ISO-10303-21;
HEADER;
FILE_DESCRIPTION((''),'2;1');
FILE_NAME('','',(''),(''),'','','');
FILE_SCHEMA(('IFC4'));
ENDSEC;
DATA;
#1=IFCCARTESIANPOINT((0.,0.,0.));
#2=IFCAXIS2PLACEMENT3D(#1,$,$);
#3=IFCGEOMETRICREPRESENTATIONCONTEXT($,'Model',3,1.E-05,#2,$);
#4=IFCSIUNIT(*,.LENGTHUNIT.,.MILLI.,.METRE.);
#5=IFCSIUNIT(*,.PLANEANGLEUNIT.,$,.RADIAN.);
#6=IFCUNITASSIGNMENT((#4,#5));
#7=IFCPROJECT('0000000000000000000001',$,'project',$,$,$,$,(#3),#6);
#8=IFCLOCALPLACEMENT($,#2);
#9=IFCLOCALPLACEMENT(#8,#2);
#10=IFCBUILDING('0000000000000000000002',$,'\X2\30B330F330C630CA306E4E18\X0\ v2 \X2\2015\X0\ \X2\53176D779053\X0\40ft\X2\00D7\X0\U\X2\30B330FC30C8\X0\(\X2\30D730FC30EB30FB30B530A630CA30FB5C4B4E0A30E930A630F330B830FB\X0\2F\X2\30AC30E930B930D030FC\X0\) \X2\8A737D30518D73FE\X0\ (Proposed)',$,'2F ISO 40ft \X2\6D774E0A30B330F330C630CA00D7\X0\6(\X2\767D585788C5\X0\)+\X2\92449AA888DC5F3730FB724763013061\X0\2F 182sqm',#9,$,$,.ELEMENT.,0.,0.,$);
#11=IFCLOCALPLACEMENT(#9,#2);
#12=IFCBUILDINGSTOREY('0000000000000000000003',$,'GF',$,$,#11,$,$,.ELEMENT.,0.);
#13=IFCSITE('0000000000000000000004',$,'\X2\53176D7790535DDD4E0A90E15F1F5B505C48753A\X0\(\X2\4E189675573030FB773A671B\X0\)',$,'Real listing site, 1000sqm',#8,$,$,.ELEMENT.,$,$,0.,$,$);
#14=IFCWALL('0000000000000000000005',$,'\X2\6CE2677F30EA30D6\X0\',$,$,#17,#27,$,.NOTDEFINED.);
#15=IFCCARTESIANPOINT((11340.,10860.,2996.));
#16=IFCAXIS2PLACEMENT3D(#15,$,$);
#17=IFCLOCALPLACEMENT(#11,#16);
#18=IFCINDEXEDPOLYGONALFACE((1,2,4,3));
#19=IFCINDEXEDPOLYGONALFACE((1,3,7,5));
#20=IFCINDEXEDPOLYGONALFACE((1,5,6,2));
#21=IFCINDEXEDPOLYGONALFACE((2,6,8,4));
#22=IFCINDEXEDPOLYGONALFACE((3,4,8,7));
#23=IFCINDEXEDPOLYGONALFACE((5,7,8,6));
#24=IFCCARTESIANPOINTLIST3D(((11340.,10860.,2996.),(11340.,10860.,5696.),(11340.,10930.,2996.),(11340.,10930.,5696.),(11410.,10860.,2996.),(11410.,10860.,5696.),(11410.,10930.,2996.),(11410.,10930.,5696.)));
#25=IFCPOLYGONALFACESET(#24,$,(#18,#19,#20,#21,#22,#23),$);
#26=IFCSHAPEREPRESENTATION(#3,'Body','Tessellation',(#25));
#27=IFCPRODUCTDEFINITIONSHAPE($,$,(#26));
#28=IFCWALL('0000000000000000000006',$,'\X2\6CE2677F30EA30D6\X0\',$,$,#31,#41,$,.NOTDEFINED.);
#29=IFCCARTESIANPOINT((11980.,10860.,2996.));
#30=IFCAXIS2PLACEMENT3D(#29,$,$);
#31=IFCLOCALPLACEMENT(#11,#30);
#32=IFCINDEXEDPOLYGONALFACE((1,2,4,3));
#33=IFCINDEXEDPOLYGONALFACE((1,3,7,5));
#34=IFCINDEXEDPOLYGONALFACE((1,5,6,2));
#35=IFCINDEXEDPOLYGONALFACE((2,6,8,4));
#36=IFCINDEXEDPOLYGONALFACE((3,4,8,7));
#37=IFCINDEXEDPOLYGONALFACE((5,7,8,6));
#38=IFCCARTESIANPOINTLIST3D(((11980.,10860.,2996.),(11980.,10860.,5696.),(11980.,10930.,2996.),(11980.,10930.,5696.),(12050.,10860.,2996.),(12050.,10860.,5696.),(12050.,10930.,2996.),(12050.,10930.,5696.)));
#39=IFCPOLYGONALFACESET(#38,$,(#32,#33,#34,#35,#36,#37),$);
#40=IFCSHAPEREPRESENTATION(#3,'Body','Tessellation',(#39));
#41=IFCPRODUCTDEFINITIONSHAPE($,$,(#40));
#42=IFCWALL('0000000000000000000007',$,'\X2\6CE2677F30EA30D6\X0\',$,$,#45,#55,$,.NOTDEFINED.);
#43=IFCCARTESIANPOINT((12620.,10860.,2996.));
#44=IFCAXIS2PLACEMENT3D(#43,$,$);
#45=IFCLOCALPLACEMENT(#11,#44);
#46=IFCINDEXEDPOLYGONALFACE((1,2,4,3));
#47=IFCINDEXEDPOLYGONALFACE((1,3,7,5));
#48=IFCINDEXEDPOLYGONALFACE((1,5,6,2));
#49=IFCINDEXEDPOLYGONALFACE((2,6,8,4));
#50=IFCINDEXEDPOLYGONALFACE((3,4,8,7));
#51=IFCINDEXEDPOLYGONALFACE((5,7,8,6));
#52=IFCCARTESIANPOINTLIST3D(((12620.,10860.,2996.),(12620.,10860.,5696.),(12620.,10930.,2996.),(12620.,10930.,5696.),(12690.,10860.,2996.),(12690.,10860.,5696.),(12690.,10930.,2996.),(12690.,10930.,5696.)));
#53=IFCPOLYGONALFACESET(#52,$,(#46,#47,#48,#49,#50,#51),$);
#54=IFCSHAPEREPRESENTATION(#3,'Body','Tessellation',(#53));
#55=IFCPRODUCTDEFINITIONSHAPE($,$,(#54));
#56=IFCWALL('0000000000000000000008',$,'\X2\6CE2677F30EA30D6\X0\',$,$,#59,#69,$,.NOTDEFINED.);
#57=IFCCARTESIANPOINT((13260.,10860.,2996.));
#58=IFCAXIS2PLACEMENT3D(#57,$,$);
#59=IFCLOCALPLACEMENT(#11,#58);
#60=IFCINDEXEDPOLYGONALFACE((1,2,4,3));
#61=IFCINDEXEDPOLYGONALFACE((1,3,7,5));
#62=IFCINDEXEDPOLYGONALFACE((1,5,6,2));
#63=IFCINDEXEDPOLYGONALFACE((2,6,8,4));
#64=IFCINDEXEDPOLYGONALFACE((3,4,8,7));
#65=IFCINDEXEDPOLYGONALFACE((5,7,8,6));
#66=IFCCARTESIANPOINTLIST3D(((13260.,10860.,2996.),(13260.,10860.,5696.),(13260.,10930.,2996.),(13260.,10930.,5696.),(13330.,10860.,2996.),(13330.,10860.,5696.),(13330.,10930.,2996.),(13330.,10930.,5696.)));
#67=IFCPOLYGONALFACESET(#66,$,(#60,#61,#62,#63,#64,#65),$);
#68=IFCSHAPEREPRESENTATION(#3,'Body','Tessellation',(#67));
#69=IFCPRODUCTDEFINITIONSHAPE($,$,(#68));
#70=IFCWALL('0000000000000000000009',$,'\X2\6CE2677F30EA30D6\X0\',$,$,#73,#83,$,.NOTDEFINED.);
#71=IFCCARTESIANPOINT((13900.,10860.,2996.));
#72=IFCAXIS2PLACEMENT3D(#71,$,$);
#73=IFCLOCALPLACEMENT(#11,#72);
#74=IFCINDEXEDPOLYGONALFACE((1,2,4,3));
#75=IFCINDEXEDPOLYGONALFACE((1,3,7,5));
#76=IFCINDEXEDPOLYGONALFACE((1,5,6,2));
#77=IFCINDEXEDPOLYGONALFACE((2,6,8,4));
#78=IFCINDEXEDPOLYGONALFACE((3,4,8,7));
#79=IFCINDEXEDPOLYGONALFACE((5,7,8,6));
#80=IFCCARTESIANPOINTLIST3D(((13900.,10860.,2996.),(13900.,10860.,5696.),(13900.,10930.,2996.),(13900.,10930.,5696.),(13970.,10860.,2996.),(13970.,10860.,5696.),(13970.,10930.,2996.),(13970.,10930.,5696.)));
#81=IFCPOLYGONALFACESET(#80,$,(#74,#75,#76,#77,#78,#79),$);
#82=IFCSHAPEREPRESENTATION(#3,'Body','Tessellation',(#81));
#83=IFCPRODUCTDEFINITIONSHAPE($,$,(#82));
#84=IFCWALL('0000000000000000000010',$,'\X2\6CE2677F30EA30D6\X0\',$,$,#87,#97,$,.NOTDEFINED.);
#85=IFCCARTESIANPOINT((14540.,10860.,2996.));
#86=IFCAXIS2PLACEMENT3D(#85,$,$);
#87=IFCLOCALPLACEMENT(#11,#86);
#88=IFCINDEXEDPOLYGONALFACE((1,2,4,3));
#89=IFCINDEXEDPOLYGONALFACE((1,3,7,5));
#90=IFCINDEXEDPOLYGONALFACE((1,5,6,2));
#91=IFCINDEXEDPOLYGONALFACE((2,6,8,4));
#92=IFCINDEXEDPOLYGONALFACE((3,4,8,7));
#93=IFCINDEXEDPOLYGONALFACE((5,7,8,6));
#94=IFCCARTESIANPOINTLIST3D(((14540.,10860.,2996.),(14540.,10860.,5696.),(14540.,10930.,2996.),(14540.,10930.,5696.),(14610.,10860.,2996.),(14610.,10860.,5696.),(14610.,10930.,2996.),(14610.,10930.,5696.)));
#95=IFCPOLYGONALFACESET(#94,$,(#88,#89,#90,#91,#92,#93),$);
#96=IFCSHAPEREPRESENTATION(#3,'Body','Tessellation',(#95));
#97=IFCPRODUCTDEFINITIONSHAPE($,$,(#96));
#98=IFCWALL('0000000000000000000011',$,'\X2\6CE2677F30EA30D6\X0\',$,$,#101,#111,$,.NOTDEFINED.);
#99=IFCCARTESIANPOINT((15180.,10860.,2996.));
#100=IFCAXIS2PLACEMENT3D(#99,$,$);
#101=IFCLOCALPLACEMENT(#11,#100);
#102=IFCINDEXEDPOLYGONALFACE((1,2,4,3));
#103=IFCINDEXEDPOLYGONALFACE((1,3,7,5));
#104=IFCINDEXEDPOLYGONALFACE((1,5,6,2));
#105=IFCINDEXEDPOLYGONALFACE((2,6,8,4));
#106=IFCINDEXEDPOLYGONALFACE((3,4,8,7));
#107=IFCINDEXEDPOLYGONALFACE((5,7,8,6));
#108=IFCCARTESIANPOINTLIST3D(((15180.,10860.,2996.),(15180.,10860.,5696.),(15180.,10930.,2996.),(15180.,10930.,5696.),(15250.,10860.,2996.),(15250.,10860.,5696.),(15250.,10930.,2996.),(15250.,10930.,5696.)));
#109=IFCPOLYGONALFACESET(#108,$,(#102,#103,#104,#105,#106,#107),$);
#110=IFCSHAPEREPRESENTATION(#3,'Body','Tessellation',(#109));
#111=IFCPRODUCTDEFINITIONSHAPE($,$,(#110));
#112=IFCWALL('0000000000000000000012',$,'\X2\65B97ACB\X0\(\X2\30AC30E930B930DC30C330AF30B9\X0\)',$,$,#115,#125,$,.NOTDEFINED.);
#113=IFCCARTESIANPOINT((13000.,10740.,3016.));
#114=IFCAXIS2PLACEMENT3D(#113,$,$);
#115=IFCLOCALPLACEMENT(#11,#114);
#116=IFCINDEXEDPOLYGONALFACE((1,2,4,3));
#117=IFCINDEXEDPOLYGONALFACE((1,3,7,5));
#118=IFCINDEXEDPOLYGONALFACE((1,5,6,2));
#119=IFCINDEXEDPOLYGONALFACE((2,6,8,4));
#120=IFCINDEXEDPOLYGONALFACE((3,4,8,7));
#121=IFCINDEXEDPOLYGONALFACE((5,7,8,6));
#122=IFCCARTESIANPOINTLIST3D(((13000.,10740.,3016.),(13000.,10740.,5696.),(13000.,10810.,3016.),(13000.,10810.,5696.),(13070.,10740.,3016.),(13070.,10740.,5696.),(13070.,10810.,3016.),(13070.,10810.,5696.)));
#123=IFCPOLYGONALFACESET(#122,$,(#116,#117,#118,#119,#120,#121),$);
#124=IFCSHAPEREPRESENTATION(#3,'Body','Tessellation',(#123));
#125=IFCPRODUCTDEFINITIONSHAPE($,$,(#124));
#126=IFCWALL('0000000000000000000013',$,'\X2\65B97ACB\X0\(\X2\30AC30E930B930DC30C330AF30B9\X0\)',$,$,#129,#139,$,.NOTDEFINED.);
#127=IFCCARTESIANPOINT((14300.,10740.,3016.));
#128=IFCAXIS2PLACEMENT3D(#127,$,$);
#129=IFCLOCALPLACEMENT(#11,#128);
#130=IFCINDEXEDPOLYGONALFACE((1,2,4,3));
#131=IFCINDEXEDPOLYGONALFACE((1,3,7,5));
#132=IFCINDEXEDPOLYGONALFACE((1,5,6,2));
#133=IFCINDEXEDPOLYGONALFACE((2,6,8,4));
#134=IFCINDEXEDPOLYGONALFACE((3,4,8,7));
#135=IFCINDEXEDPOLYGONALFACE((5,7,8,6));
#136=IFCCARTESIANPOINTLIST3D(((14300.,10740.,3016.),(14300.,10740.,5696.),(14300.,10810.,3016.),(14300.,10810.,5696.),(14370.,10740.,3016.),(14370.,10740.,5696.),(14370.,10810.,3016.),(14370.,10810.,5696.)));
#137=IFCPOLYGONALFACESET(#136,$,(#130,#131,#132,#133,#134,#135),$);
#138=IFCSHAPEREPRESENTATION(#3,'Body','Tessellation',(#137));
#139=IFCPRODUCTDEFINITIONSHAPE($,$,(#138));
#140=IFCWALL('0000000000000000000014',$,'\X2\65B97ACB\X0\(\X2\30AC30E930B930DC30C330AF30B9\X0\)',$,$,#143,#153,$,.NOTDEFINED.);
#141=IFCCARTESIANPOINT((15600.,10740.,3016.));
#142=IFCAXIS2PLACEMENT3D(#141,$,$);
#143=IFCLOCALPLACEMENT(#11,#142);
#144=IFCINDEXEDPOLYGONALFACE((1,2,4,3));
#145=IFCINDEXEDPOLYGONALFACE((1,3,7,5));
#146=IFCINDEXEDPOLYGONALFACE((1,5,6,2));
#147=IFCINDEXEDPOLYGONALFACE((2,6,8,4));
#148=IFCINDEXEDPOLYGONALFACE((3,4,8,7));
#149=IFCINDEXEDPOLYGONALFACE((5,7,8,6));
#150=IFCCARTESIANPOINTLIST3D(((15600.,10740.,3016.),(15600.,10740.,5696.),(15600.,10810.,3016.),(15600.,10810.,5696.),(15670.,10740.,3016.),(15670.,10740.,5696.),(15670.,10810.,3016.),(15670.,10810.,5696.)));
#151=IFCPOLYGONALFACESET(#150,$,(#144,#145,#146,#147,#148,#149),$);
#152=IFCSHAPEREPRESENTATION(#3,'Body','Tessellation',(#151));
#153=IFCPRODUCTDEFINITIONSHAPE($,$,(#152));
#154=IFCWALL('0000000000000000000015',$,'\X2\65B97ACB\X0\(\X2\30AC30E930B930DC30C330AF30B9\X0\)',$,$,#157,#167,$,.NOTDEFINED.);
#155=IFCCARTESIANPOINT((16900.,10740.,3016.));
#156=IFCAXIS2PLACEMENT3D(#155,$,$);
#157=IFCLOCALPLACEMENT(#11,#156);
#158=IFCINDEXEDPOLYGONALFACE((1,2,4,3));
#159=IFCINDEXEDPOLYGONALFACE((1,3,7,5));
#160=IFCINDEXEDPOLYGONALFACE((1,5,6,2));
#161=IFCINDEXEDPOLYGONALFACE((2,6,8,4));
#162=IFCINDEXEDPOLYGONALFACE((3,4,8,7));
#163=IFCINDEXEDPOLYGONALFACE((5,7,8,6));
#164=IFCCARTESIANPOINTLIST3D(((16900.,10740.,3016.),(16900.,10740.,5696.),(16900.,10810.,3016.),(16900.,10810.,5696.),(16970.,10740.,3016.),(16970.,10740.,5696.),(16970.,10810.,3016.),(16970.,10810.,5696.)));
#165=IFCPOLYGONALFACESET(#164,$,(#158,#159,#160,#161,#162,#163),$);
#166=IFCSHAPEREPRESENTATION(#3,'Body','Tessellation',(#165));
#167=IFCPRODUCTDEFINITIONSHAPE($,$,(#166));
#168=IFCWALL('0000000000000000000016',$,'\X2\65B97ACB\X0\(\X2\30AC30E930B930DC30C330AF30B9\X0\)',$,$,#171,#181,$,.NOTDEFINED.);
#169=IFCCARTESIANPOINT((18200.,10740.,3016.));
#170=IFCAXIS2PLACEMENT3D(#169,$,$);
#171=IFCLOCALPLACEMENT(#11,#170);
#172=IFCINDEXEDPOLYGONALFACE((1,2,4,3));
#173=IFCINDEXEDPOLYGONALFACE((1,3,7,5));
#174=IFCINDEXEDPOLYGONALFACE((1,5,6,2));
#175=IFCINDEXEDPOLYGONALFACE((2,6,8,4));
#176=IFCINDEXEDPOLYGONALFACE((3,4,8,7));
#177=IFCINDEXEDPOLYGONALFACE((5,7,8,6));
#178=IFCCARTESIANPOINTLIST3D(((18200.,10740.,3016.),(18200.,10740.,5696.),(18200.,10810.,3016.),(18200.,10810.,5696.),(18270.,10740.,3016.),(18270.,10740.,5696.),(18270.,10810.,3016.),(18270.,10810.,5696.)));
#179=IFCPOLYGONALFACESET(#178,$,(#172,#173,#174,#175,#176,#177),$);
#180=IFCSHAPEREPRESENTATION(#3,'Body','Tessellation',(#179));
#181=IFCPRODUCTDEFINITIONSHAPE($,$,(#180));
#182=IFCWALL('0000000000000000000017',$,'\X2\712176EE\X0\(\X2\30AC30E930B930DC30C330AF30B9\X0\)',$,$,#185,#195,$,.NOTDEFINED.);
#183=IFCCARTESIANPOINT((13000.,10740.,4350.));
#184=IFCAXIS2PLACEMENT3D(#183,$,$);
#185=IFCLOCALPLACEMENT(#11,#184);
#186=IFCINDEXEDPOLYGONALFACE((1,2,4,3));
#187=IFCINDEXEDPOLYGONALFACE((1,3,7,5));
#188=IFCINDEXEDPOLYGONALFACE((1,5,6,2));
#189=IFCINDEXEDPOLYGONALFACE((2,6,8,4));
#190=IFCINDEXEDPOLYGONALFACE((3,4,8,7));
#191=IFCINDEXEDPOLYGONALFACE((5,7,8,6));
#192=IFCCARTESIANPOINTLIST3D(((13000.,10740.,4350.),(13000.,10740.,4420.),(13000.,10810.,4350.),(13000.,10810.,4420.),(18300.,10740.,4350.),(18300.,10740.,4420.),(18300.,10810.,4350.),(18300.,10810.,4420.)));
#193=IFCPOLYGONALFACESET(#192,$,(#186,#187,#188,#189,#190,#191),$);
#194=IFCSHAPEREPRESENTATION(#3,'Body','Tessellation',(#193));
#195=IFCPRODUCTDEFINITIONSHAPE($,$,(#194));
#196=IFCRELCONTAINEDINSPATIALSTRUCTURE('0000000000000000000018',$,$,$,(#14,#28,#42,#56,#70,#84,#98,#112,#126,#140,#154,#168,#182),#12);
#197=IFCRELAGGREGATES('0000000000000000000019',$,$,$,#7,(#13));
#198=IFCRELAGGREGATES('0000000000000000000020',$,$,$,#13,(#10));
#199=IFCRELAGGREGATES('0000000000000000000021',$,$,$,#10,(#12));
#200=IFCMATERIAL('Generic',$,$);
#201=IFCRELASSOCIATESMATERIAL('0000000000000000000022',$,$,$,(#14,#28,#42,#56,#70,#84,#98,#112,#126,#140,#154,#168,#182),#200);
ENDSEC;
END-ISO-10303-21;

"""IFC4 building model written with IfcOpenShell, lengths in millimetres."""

from ifc_helpers import new_model, si_unit, frame, frame_2d, origin, place, context, project, spatial, rectangle, extrude, material, element, save


model = new_model("IFC4")

# Units and contexts
model_context = context("Model", 3, precision=1e-05, world=origin())
ifc_project = project(units=[si_unit("LENGTHUNIT", "METRE", prefix="MILLI"), si_unit("PLANEANGLEUNIT", "RADIAN")], contexts=[model_context])

# Site, building, storey
site_placement = place(None, origin())
site = spatial("IfcSite", under=ifc_project, at=site_placement, Name="北海道川上郡弟子屈町(丘陵地・眺望)", ObjectType="Real listing site, 1000sqm", CompositionType="ELEMENT", RefElevation=0.0)
building_placement = place(site_placement, origin())
building = spatial("IfcBuilding", under=site, at=building_placement, Name="コンテナの丘 v2 ― 北海道40ft×Uコート(プール・サウナ・屋上ラウンジ・2Fガラスバー) 詳細再現 (Proposed)", ObjectType="2F ISO 40ft 海上コンテナ×6(白塗装)+鉄骨補強・片持ち2F 182sqm", CompositionType="ELEMENT", ElevationOfRefHeight=0.0, ElevationOfTerrain=0.0)
storey_placement = place(building_placement, origin())
storey = spatial("IfcBuildingStorey", under=building, at=storey_placement, Name="GF", CompositionType="ELEMENT", Elevation=0.0)

# Shared definitions
ifc_material = material(Name="Generic")

# Walls
wall_1_placement = place(storey_placement, frame((11340.0, 10860.0, 2996.0)))
element("IfcWall", 1, at=wall_1_placement, inside=storey, material=ifc_material, Name="波板リブ", PredefinedType="NOTDEFINED", context=model_context, shape_type="SweptSolid", body=[
    extrude(rectangle(XDim=70.0, YDim=70.0, at=frame_2d((35.0, 35.0))), frame((11340.0, 10860.0, 2996.0)), (0.0, 0.0, 1.0), 2700.0),
])
wall_2_placement = place(storey_placement, frame((11980.0, 10860.0, 2996.0)))
element("IfcWall", 2, at=wall_2_placement, inside=storey, material=ifc_material, Name="波板リブ", PredefinedType="NOTDEFINED", context=model_context, shape_type="SweptSolid", body=[
    extrude(rectangle(XDim=70.0, YDim=70.0, at=frame_2d((35.0, 35.0))), frame((11980.0, 10860.0, 2996.0)), (0.0, 0.0, 1.0), 2700.0),
])
wall_3_placement = place(storey_placement, frame((12620.0, 10860.0, 2996.0)))
element("IfcWall", 3, at=wall_3_placement, inside=storey, material=ifc_material, Name="波板リブ", PredefinedType="NOTDEFINED", context=model_context, shape_type="SweptSolid", body=[
    extrude(rectangle(XDim=70.0, YDim=70.0, at=frame_2d((35.0, 35.0))), frame((12620.0, 10860.0, 2996.0)), (0.0, 0.0, 1.0), 2700.0),
])
wall_4_placement = place(storey_placement, frame((13260.0, 10860.0, 2996.0)))
element("IfcWall", 4, at=wall_4_placement, inside=storey, material=ifc_material, Name="波板リブ", PredefinedType="NOTDEFINED", context=model_context, shape_type="SweptSolid", body=[
    extrude(rectangle(XDim=70.0, YDim=70.0, at=frame_2d((35.0, 35.0))), frame((13260.0, 10860.0, 2996.0)), (0.0, 0.0, 1.0), 2700.0),
])
wall_5_placement = place(storey_placement, frame((13900.0, 10860.0, 2996.0)))
element("IfcWall", 5, at=wall_5_placement, inside=storey, material=ifc_material, Name="波板リブ", PredefinedType="NOTDEFINED", context=model_context, shape_type="SweptSolid", body=[
    extrude(rectangle(XDim=70.0, YDim=70.0, at=frame_2d((35.0, 35.0))), frame((13900.0, 10860.0, 2996.0)), (0.0, 0.0, 1.0), 2700.0),
])
wall_6_placement = place(storey_placement, frame((14540.0, 10860.0, 2996.0)))
element("IfcWall", 6, at=wall_6_placement, inside=storey, material=ifc_material, Name="波板リブ", PredefinedType="NOTDEFINED", context=model_context, shape_type="SweptSolid", body=[
    extrude(rectangle(XDim=70.0, YDim=70.0, at=frame_2d((35.0, 35.0))), frame((14540.0, 10860.0, 2996.0)), (0.0, 0.0, 1.0), 2700.0),
])
wall_7_placement = place(storey_placement, frame((15180.0, 10860.0, 2996.0)))
element("IfcWall", 7, at=wall_7_placement, inside=storey, material=ifc_material, Name="波板リブ", PredefinedType="NOTDEFINED", context=model_context, shape_type="SweptSolid", body=[
    extrude(rectangle(XDim=70.0, YDim=70.0, at=frame_2d((35.0, 35.0))), frame((15180.0, 10860.0, 2996.0)), (0.0, 0.0, 1.0), 2700.0),
])
wall_8_placement = place(storey_placement, frame((13000.0, 10740.0, 3016.0)))
element("IfcWall", 8, at=wall_8_placement, inside=storey, material=ifc_material, Name="方立(ガラスボックス)", PredefinedType="NOTDEFINED", context=model_context, shape_type="SweptSolid", body=[
    extrude(rectangle(XDim=70.0, YDim=70.0, at=frame_2d((35.0, 35.0))), frame((13000.0, 10740.0, 3016.0)), (0.0, 0.0, 1.0), 2680.0),
])
wall_9_placement = place(storey_placement, frame((14300.0, 10740.0, 3016.0)))
element("IfcWall", 9, at=wall_9_placement, inside=storey, material=ifc_material, Name="方立(ガラスボックス)", PredefinedType="NOTDEFINED", context=model_context, shape_type="SweptSolid", body=[
    extrude(rectangle(XDim=70.0, YDim=70.0, at=frame_2d((35.0, 35.0))), frame((14300.0, 10740.0, 3016.0)), (0.0, 0.0, 1.0), 2680.0),
])
wall_10_placement = place(storey_placement, frame((15600.0, 10740.0, 3016.0)))
element("IfcWall", 10, at=wall_10_placement, inside=storey, material=ifc_material, Name="方立(ガラスボックス)", PredefinedType="NOTDEFINED", context=model_context, shape_type="SweptSolid", body=[
    extrude(rectangle(XDim=70.0, YDim=70.0, at=frame_2d((35.0, 35.0))), frame((15600.0, 10740.0, 3016.0)), (0.0, 0.0, 1.0), 2680.0),
])
wall_11_placement = place(storey_placement, frame((16900.0, 10740.0, 3016.0)))
element("IfcWall", 11, at=wall_11_placement, inside=storey, material=ifc_material, Name="方立(ガラスボックス)", PredefinedType="NOTDEFINED", context=model_context, shape_type="SweptSolid", body=[
    extrude(rectangle(XDim=70.0, YDim=70.0, at=frame_2d((35.0, 35.0))), frame((16900.0, 10740.0, 3016.0)), (0.0, 0.0, 1.0), 2680.0),
])
wall_12_placement = place(storey_placement, frame((18200.0, 10740.0, 3016.0)))
element("IfcWall", 12, at=wall_12_placement, inside=storey, material=ifc_material, Name="方立(ガラスボックス)", PredefinedType="NOTDEFINED", context=model_context, shape_type="SweptSolid", body=[
    extrude(rectangle(XDim=70.0, YDim=70.0, at=frame_2d((35.0, 35.0))), frame((18200.0, 10740.0, 3016.0)), (0.0, 0.0, 1.0), 2680.0),
])
wall_13_placement = place(storey_placement, frame((13000.0, 10740.0, 4350.0)))
element("IfcWall", 13, at=wall_13_placement, inside=storey, material=ifc_material, Name="無目(ガラスボックス)", PredefinedType="NOTDEFINED", context=model_context, shape_type="SweptSolid", body=[
    extrude(rectangle(XDim=5300.0, YDim=70.0, at=frame_2d((2650.0, 35.0))), frame((13000.0, 10740.0, 4350.0)), (0.0, 0.0, 1.0), 70.0),
])

save(model, "model.ifc")
